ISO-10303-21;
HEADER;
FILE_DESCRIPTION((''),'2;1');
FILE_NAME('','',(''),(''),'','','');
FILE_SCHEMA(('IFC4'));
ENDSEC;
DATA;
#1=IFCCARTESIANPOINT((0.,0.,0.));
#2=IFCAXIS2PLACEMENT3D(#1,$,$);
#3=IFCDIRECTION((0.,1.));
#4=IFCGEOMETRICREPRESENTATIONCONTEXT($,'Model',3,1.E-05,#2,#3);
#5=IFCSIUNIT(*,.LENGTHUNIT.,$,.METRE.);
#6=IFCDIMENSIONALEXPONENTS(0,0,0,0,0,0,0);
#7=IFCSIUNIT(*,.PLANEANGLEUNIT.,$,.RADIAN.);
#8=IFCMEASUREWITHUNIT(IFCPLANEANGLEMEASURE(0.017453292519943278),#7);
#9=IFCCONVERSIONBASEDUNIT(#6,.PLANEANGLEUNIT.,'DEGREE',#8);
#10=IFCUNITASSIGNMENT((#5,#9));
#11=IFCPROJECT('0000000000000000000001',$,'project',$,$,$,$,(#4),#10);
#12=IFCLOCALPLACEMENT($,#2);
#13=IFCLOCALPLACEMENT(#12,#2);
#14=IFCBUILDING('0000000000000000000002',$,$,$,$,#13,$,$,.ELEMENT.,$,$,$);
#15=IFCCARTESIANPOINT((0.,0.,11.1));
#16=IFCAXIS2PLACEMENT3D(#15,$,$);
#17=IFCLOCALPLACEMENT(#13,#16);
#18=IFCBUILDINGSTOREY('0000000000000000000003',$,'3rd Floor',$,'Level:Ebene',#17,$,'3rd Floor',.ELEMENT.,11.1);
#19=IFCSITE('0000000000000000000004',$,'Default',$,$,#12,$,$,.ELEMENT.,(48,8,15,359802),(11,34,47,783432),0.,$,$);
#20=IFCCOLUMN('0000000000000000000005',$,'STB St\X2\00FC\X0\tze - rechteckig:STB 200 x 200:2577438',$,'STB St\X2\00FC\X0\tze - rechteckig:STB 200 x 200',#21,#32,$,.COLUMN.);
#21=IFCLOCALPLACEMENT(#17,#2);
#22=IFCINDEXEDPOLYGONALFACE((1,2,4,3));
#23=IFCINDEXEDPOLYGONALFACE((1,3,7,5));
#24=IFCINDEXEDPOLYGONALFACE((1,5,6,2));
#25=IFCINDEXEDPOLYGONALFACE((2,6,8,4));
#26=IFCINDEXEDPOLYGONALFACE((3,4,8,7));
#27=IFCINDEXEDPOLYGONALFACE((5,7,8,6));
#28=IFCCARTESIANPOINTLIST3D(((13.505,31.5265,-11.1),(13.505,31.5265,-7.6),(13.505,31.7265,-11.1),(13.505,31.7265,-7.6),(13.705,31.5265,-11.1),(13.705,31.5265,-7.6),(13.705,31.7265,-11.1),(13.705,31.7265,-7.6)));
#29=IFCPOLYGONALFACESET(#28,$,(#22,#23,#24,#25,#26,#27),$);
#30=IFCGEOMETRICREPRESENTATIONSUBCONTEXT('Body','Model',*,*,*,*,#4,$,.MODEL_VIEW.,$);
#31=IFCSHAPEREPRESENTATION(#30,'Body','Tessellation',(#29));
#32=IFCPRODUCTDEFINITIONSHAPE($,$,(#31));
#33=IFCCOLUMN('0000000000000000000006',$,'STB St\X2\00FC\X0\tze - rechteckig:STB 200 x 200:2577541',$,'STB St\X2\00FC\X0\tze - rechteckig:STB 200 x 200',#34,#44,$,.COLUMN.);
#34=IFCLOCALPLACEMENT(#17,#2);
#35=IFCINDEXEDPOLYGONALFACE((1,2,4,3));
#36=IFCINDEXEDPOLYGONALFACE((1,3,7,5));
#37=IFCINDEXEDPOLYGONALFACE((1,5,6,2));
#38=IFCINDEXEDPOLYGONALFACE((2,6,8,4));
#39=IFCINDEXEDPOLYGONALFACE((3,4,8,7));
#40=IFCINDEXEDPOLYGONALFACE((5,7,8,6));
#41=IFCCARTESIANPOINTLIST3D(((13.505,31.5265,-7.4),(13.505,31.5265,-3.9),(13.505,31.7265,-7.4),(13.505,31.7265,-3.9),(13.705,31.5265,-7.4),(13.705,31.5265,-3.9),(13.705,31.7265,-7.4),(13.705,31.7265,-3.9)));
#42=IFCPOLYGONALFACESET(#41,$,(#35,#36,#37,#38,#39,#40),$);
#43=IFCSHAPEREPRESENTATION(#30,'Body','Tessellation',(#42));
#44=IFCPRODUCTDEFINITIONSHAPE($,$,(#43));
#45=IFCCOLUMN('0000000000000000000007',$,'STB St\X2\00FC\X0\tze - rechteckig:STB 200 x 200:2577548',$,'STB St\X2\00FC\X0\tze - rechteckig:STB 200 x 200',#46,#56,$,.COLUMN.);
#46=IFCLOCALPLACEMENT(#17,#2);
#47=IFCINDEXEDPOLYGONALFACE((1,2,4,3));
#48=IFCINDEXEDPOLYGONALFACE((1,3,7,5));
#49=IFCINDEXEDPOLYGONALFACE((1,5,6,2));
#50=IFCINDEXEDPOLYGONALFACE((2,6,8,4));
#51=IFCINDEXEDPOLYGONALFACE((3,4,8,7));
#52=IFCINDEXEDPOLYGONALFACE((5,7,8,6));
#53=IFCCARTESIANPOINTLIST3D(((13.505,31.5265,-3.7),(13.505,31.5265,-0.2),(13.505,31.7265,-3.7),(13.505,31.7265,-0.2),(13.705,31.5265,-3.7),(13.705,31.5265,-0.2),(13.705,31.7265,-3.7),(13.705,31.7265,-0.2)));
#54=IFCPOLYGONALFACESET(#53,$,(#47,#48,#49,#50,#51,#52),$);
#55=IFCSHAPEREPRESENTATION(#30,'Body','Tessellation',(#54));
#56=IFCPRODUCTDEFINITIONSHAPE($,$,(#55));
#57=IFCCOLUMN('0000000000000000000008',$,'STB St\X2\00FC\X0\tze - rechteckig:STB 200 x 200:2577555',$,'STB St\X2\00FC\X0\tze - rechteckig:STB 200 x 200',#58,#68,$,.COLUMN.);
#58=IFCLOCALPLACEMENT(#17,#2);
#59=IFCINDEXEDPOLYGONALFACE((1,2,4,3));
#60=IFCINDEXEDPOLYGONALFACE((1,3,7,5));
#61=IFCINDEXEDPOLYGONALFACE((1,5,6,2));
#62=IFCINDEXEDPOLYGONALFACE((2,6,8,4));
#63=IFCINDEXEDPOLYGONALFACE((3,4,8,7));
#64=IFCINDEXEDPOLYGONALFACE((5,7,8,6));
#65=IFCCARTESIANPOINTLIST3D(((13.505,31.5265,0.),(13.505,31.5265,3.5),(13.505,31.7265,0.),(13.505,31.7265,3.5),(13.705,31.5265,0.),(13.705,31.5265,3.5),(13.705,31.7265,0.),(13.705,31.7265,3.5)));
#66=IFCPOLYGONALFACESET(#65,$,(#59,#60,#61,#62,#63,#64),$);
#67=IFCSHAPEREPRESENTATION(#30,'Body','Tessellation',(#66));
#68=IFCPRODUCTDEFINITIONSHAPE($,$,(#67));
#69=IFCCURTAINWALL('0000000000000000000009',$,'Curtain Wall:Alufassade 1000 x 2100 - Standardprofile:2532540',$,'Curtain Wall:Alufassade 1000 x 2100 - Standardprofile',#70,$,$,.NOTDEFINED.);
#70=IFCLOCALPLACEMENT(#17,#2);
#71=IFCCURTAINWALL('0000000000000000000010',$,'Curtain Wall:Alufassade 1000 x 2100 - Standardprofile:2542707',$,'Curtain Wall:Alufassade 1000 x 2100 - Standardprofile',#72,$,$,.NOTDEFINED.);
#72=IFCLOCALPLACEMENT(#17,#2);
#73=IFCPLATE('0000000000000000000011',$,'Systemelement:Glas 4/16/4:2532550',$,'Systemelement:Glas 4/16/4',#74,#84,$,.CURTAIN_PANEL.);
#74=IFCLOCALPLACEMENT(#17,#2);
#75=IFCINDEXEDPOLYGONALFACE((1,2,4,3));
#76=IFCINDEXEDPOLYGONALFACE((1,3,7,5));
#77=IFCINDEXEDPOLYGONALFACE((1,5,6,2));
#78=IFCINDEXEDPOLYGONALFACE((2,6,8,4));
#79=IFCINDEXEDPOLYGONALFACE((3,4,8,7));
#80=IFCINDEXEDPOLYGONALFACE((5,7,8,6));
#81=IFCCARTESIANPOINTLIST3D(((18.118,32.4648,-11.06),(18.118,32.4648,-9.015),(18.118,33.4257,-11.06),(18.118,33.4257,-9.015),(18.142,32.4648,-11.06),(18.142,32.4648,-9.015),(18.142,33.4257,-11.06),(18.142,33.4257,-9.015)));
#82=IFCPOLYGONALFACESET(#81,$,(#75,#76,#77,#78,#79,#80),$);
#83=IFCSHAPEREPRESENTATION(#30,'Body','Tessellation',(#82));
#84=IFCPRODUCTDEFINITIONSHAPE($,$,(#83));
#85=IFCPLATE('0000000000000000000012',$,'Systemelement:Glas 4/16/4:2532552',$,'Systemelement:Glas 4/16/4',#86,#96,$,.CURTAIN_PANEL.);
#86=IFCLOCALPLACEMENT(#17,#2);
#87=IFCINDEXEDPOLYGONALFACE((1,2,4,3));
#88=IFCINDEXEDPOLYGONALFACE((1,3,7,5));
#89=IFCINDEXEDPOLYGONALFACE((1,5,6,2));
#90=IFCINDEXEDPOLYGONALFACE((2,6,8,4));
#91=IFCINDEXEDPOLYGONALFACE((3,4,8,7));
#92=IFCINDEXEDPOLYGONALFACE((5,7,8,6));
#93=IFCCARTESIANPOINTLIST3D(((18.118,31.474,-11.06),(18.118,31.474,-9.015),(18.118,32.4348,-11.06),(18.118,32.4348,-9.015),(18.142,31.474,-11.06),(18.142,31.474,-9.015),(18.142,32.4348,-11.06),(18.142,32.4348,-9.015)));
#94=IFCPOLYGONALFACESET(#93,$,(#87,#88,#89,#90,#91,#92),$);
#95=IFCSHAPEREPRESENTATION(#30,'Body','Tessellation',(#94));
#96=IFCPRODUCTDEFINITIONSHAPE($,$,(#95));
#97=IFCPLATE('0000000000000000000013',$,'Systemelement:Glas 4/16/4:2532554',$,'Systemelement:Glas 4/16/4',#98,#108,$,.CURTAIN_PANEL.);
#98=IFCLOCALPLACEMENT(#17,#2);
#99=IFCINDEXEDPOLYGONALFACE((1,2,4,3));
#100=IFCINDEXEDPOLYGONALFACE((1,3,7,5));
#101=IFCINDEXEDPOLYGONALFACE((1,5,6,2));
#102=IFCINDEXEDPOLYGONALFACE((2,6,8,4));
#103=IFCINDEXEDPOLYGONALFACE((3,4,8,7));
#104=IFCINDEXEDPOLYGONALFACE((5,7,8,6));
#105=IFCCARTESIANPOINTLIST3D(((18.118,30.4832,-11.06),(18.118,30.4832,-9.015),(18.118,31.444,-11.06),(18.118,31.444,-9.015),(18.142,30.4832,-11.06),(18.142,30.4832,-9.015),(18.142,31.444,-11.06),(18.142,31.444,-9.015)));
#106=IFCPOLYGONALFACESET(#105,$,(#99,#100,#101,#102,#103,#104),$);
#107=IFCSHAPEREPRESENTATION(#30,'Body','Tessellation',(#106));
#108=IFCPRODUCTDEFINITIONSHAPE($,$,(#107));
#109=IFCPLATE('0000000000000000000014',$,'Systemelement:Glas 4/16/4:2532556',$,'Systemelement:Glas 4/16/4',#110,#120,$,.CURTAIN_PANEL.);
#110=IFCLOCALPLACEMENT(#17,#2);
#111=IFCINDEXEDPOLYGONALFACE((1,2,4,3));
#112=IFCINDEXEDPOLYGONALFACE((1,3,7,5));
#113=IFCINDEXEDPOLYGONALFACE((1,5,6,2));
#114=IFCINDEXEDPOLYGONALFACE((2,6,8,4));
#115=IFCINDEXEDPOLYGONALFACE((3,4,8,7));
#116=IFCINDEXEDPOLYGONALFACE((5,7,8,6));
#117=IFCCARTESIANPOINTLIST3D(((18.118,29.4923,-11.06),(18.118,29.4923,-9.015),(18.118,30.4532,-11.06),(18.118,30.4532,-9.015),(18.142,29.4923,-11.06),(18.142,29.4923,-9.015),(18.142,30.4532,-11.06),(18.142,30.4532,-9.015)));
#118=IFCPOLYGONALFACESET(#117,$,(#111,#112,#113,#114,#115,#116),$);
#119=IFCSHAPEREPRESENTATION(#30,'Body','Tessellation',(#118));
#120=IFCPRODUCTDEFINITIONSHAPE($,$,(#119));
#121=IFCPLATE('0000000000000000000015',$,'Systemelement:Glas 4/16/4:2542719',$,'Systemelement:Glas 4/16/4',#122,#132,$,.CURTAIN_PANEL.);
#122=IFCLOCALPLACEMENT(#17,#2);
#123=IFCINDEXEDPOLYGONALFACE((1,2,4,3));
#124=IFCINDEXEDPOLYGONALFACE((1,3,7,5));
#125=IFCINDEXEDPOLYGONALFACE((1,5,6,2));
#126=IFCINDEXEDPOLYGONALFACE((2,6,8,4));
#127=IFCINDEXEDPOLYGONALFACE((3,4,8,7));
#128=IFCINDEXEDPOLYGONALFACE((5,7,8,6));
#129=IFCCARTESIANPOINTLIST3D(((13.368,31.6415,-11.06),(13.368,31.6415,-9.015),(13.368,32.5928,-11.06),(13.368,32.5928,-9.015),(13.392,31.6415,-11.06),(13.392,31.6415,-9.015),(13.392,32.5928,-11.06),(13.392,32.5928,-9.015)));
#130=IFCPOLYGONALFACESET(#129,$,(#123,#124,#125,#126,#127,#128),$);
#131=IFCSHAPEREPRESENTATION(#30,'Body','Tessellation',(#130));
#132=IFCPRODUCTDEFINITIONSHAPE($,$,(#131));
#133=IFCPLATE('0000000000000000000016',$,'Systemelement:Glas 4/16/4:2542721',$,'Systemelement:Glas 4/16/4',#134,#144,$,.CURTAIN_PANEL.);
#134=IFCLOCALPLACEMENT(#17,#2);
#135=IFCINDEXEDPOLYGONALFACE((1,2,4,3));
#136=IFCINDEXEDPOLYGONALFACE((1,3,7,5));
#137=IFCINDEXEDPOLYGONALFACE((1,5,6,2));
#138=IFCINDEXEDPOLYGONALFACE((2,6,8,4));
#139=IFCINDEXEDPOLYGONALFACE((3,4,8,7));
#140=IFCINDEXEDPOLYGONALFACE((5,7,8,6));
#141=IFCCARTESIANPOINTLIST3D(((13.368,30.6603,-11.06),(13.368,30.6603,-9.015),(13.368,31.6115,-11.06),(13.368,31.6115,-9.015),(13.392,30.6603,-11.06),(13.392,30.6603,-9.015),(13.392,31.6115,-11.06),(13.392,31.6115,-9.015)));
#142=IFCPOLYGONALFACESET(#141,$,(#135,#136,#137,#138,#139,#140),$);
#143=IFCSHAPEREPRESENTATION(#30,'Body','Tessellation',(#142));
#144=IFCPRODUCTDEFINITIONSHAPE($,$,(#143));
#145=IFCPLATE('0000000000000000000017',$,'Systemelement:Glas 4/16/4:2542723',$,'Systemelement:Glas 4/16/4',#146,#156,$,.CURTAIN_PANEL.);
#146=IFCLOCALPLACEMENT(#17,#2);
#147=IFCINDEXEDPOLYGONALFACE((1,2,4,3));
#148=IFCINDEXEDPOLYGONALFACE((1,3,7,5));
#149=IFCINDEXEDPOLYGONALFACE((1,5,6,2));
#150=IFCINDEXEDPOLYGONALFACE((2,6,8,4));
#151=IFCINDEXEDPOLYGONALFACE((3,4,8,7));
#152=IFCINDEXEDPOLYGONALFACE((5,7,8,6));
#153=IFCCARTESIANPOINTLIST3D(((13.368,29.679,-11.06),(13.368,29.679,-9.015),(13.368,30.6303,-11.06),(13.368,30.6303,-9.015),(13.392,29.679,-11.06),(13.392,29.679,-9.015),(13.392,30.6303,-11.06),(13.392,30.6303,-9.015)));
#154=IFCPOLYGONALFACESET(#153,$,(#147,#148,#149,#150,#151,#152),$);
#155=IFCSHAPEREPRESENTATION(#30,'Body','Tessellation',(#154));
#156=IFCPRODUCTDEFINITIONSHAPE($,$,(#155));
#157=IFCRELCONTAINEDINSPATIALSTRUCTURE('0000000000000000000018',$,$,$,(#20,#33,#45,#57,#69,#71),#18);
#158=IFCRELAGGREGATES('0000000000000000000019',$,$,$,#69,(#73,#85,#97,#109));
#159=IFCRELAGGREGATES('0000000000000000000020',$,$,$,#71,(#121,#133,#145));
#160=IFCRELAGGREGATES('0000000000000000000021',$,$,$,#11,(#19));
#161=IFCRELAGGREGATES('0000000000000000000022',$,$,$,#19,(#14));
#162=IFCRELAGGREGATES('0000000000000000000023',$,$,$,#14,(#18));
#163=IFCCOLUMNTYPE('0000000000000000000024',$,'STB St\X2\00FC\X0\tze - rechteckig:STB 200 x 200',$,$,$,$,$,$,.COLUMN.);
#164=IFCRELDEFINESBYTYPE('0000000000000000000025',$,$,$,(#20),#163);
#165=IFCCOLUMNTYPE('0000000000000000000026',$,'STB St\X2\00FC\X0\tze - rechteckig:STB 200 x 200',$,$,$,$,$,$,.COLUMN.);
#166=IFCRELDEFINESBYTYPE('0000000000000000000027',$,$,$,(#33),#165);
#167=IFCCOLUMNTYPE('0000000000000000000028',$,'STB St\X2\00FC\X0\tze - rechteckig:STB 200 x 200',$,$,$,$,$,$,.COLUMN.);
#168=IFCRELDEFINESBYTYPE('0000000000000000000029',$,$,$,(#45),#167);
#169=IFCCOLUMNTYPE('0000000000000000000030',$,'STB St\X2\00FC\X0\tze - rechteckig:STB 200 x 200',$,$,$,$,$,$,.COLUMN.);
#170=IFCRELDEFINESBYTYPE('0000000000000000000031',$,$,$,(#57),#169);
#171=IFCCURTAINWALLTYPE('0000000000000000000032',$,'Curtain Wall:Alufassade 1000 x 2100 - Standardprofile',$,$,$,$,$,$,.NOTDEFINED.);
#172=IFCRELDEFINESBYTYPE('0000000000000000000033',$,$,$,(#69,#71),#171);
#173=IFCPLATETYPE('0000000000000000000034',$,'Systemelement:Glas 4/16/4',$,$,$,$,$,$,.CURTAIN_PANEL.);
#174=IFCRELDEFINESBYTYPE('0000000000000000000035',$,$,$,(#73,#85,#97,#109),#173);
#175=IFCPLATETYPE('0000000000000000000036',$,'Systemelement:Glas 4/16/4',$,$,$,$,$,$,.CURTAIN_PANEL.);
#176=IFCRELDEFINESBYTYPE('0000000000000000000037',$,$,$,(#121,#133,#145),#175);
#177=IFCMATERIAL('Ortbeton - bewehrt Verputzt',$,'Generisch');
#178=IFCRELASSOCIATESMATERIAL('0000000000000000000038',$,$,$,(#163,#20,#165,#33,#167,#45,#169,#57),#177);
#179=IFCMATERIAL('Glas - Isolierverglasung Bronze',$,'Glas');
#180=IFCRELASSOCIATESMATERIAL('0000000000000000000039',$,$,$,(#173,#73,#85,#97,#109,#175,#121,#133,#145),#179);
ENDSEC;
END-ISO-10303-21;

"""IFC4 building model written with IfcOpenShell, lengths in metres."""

from ifc_helpers import new_model, entity, si_unit, converted_unit, direction, frame, origin, place, context, subcontext, project, spatial, indexed_curve, outline, extrude, source, transform, mapped, material, type_object, type_shapes, element, aggregate, save


model = new_model("IFC4")

# Units and contexts
model_context = context("Model", 3, precision=1e-05, world=origin(), true_north=direction((0.0, 1.0)))
body_context = subcontext(model_context, "Body", "Model", "MODEL_VIEW")
ifc_project = project(units=[si_unit("LENGTHUNIT", "METRE"), converted_unit("PLANEANGLEUNIT", "DEGREE", entity("IfcPlaneAngleMeasure", 0.017453292519943278), si_unit("PLANEANGLEUNIT", "RADIAN"), dimensions=[0, 0, 0, 0, 0, 0, 0])], contexts=[model_context])

# Site, building, storey
site_placement = place(None, origin())
site = spatial("IfcSite", under=ifc_project, at=site_placement, Name="Default", CompositionType="ELEMENT", RefLatitude=(48, 8, 15, 359802), RefLongitude=(11, 34, 47, 783432), RefElevation=0.0)
building_placement = place(site_placement, origin())
building = spatial("IfcBuilding", under=site, at=building_placement, CompositionType="ELEMENT")
storey_placement = place(building_placement, frame((0.0, 0.0, 11.1)))
storey = spatial("IfcBuildingStorey", under=building, at=storey_placement, Name="3rd Floor", ObjectType="Level:Ebene", LongName="3rd Floor", CompositionType="ELEMENT", Elevation=11.1)

# Columns
ifc_material_1 = material(Name="Ortbeton - bewehrt Verputzt", Category="Generisch")
column_type_1 = type_object("IfcColumnType", Name="STB Stütze - rechteckig:STB 200 x 200", PredefinedType="COLUMN", material=ifc_material_1)
shared_shape_1 = source(origin(), body_context, "Body", "SweptSolid", [
    extrude(outline(indexed_curve([(-0.1, -0.1), (0.1, -0.1), (0.1, 0.1), (-0.1, 0.1), (-0.1, -0.1)], self_intersect=False)), frame((0.0, 0.0, 0.0), z_axis=(0.0, 0.0, 1.0), x_axis=(-1.0, 0.0, 0.0)), (0.0, 0.0, 1.0), 3.5),
])
type_shapes(column_type_1, [shared_shape_1])
column_1_placement = place(storey_placement, frame((13.605, 31.6265, -11.1)))
element("IfcColumn", 1, at=column_1_placement, inside=storey, type_object=column_type_1, material=ifc_material_1, Name="STB Stütze - rechteckig:STB 200 x 200:2577438", ObjectType="STB Stütze - rechteckig:STB 200 x 200", PredefinedType="COLUMN", context=body_context, shape_type="MappedRepresentation", body=[
    mapped(shared_shape_1, transform((0.0, 0.0, 0.0), scale=1.0)),
])
column_type_2 = type_object("IfcColumnType", Name="STB Stütze - rechteckig:STB 200 x 200", PredefinedType="COLUMN", material=ifc_material_1)
shared_shape_2 = source(origin(), body_context, "Body", "SweptSolid", [
    extrude(outline(indexed_curve([(-0.1, -0.1), (0.1, -0.1), (0.1, 0.1), (-0.1, 0.1), (-0.1, -0.1)], self_intersect=False)), frame((0.0, 0.0, 3.7), z_axis=(0.0, 0.0, 1.0), x_axis=(-1.0, 0.0, 0.0)), (0.0, 0.0, 1.0), 3.5),
])
type_shapes(column_type_2, [shared_shape_2])
column_2_placement = place(storey_placement, frame((13.605, 31.6265, -11.1)))
element("IfcColumn", 2, at=column_2_placement, inside=storey, type_object=column_type_2, material=ifc_material_1, Name="STB Stütze - rechteckig:STB 200 x 200:2577541", ObjectType="STB Stütze - rechteckig:STB 200 x 200", PredefinedType="COLUMN", context=body_context, shape_type="MappedRepresentation", body=[
    mapped(shared_shape_2, transform((0.0, 0.0, 0.0), scale=1.0)),
])
column_type_3 = type_object("IfcColumnType", Name="STB Stütze - rechteckig:STB 200 x 200", PredefinedType="COLUMN", material=ifc_material_1)
shared_shape_3 = source(origin(), body_context, "Body", "SweptSolid", [
    extrude(outline(indexed_curve([(-0.1, -0.1), (0.1, -0.1), (0.1, 0.1), (-0.1, 0.1), (-0.1, -0.1)], self_intersect=False)), frame((0.0, 0.0, 7.4), z_axis=(0.0, 0.0, 1.0), x_axis=(-1.0, 0.0, 0.0)), (0.0, 0.0, 1.0), 3.5),
])
type_shapes(column_type_3, [shared_shape_3])
column_3_placement = place(storey_placement, frame((13.605, 31.6265, -11.1)))
element("IfcColumn", 3, at=column_3_placement, inside=storey, type_object=column_type_3, material=ifc_material_1, Name="STB Stütze - rechteckig:STB 200 x 200:2577548", ObjectType="STB Stütze - rechteckig:STB 200 x 200", PredefinedType="COLUMN", context=body_context, shape_type="MappedRepresentation", body=[
    mapped(shared_shape_3, transform((0.0, 0.0, 0.0), scale=1.0)),
])
column_type_4 = type_object("IfcColumnType", Name="STB Stütze - rechteckig:STB 200 x 200", PredefinedType="COLUMN", material=ifc_material_1)
shared_shape_4 = source(origin(), body_context, "Body", "SweptSolid", [
    extrude(outline(indexed_curve([(-0.1, -0.1), (0.1, -0.1), (0.1, 0.1), (-0.1, 0.1), (-0.1, -0.1)], self_intersect=False)), frame((0.0, 0.0, 11.1), z_axis=(0.0, 0.0, 1.0), x_axis=(-1.0, 0.0, 0.0)), (0.0, 0.0, 1.0), 3.5),
])
type_shapes(column_type_4, [shared_shape_4])
column_4_placement = place(storey_placement, frame((13.605, 31.6265, -11.1)))
element("IfcColumn", 4, at=column_4_placement, inside=storey, type_object=column_type_4, material=ifc_material_1, Name="STB Stütze - rechteckig:STB 200 x 200:2577555", ObjectType="STB Stütze - rechteckig:STB 200 x 200", PredefinedType="COLUMN", context=body_context, shape_type="MappedRepresentation", body=[
    mapped(shared_shape_4, transform((0.0, 0.0, 0.0), scale=1.0)),
])

# Curtain walls
curtain_wall_type = type_object("IfcCurtainWallType", Name="Curtain Wall:Alufassade 1000 x 2100 - Standardprofile", PredefinedType="NOTDEFINED")
curtain_wall_1_placement = place(storey_placement, frame((0.0, 0.0, -11.1)))
curtain_wall_1 = element("IfcCurtainWall", 5, at=curtain_wall_1_placement, inside=storey, type_object=curtain_wall_type, Name="Curtain Wall:Alufassade 1000 x 2100 - Standardprofile:2532540", ObjectType="Curtain Wall:Alufassade 1000 x 2100 - Standardprofile", PredefinedType="NOTDEFINED")
curtain_wall_2_placement = place(storey_placement, frame((0.0, 0.0, -11.1)))
curtain_wall_2 = element("IfcCurtainWall", 6, at=curtain_wall_2_placement, inside=storey, type_object=curtain_wall_type, Name="Curtain Wall:Alufassade 1000 x 2100 - Standardprofile:2542707", ObjectType="Curtain Wall:Alufassade 1000 x 2100 - Standardprofile", PredefinedType="NOTDEFINED")

# Plates
ifc_material_2 = material(Name="Glas - Isolierverglasung Bronze", Category="Glas")
plate_type_1 = type_object("IfcPlateType", Name="Systemelement:Glas 4/16/4", PredefinedType="CURTAIN_PANEL", material=ifc_material_2)
shared_shape_5 = source(origin(), body_context, "Body", "SweptSolid", [
    extrude(outline(indexed_curve([(-0.012, -0.4804), (0.012, -0.4804), (0.012, 0.4804), (-0.012, 0.4804), (-0.012, -0.4804)], self_intersect=False)), frame((0.0, 0.0, 0.0), z_axis=(0.0, 0.0, 1.0), x_axis=(0.0, 1.0, 0.0)), (0.0, 0.0, 1.0), 2.045),
])
type_shapes(plate_type_1, [shared_shape_5])
plate_1_placement = place(curtain_wall_1_placement, frame((18.13, 32.9453, 0.04), z_axis=(0.0, 0.0, 1.0), x_axis=(0.0, -1.0, 0.0)))
plate_1 = element("IfcPlate", 7, at=plate_1_placement, type_object=plate_type_1, material=ifc_material_2, Name="Systemelement:Glas 4/16/4:2532550", ObjectType="Systemelement:Glas 4/16/4", PredefinedType="CURTAIN_PANEL", context=body_context, shape_type="MappedRepresentation", body=[
    mapped(shared_shape_5, transform((0.0, 0.0, 0.0), scale=1.0)),
])
plate_2_placement = place(curtain_wall_1_placement, frame((18.13, 31.9544, 0.04), z_axis=(0.0, 0.0, 1.0), x_axis=(0.0, -1.0, 0.0)))
plate_2 = element("IfcPlate", 8, at=plate_2_placement, type_object=plate_type_1, material=ifc_material_2, Name="Systemelement:Glas 4/16/4:2532552", ObjectType="Systemelement:Glas 4/16/4", PredefinedType="CURTAIN_PANEL", context=body_context, shape_type="MappedRepresentation", body=[
    mapped(shared_shape_5, transform((0.0, 0.0, 0.0), scale=1.0)),
])
plate_3_placement = place(curtain_wall_1_placement, frame((18.13, 30.9636, 0.04), z_axis=(0.0, 0.0, 1.0), x_axis=(0.0, -1.0, 0.0)))
plate_3 = element("IfcPlate", 9, at=plate_3_placement, type_object=plate_type_1, material=ifc_material_2, Name="Systemelement:Glas 4/16/4:2532554", ObjectType="Systemelement:Glas 4/16/4", PredefinedType="CURTAIN_PANEL", context=body_context, shape_type="MappedRepresentation", body=[
    mapped(shared_shape_5, transform((0.0, 0.0, 0.0), scale=1.0)),
])
plate_4_placement = place(curtain_wall_1_placement, frame((18.13, 29.9728, 0.04), z_axis=(0.0, 0.0, 1.0), x_axis=(0.0, -1.0, 0.0)))
plate_4 = element("IfcPlate", 10, at=plate_4_placement, type_object=plate_type_1, material=ifc_material_2, Name="Systemelement:Glas 4/16/4:2532556", ObjectType="Systemelement:Glas 4/16/4", PredefinedType="CURTAIN_PANEL", context=body_context, shape_type="MappedRepresentation", body=[
    mapped(shared_shape_5, transform((0.0, 0.0, 0.0), scale=1.0)),
])
aggregate(curtain_wall_1, [plate_1, plate_2, plate_3, plate_4])
plate_type_2 = type_object("IfcPlateType", Name="Systemelement:Glas 4/16/4", PredefinedType="CURTAIN_PANEL", material=ifc_material_2)
shared_shape_6 = source(origin(), body_context, "Body", "SweptSolid", [
    extrude(outline(indexed_curve([(-0.012, -0.4756), (0.012, -0.4756), (0.012, 0.4756), (-0.012, 0.4756), (-0.012, -0.4756)], self_intersect=False)), frame((0.0, 0.0, 0.0), z_axis=(0.0, 0.0, 1.0), x_axis=(0.0, 1.0, 0.0)), (0.0, 0.0, 1.0), 2.045),
])
type_shapes(plate_type_2, [shared_shape_6])
plate_5_placement = place(curtain_wall_2_placement, frame((13.38, 32.1171, 0.04), z_axis=(0.0, 0.0, 1.0), x_axis=(0.0, -1.0, 0.0)))
plate_5 = element("IfcPlate", 11, at=plate_5_placement, type_object=plate_type_2, material=ifc_material_2, Name="Systemelement:Glas 4/16/4:2542719", ObjectType="Systemelement:Glas 4/16/4", PredefinedType="CURTAIN_PANEL", context=body_context, shape_type="MappedRepresentation", body=[
    mapped(shared_shape_6, transform((0.0, 0.0, 0.0), scale=1.0)),
])
plate_6_placement = place(curtain_wall_2_placement, frame((13.38, 31.1359, 0.04), z_axis=(0.0, 0.0, 1.0), x_axis=(0.0, -1.0, 0.0)))
plate_6 = element("IfcPlate", 12, at=plate_6_placement, type_object=plate_type_2, material=ifc_material_2, Name="Systemelement:Glas 4/16/4:2542721", ObjectType="Systemelement:Glas 4/16/4", PredefinedType="CURTAIN_PANEL", context=body_context, shape_type="MappedRepresentation", body=[
    mapped(shared_shape_6, transform((0.0, 0.0, 0.0), scale=1.0)),
])
plate_7_placement = place(curtain_wall_2_placement, frame((13.38, 30.1546, 0.04), z_axis=(0.0, 0.0, 1.0), x_axis=(0.0, -1.0, 0.0)))
plate_7 = element("IfcPlate", 13, at=plate_7_placement, type_object=plate_type_2, material=ifc_material_2, Name="Systemelement:Glas 4/16/4:2542723", ObjectType="Systemelement:Glas 4/16/4", PredefinedType="CURTAIN_PANEL", context=body_context, shape_type="MappedRepresentation", body=[
    mapped(shared_shape_6, transform((0.0, 0.0, 0.0), scale=1.0)),
])
aggregate(curtain_wall_2, [plate_5, plate_6, plate_7])

save(model, "model.ifc")
